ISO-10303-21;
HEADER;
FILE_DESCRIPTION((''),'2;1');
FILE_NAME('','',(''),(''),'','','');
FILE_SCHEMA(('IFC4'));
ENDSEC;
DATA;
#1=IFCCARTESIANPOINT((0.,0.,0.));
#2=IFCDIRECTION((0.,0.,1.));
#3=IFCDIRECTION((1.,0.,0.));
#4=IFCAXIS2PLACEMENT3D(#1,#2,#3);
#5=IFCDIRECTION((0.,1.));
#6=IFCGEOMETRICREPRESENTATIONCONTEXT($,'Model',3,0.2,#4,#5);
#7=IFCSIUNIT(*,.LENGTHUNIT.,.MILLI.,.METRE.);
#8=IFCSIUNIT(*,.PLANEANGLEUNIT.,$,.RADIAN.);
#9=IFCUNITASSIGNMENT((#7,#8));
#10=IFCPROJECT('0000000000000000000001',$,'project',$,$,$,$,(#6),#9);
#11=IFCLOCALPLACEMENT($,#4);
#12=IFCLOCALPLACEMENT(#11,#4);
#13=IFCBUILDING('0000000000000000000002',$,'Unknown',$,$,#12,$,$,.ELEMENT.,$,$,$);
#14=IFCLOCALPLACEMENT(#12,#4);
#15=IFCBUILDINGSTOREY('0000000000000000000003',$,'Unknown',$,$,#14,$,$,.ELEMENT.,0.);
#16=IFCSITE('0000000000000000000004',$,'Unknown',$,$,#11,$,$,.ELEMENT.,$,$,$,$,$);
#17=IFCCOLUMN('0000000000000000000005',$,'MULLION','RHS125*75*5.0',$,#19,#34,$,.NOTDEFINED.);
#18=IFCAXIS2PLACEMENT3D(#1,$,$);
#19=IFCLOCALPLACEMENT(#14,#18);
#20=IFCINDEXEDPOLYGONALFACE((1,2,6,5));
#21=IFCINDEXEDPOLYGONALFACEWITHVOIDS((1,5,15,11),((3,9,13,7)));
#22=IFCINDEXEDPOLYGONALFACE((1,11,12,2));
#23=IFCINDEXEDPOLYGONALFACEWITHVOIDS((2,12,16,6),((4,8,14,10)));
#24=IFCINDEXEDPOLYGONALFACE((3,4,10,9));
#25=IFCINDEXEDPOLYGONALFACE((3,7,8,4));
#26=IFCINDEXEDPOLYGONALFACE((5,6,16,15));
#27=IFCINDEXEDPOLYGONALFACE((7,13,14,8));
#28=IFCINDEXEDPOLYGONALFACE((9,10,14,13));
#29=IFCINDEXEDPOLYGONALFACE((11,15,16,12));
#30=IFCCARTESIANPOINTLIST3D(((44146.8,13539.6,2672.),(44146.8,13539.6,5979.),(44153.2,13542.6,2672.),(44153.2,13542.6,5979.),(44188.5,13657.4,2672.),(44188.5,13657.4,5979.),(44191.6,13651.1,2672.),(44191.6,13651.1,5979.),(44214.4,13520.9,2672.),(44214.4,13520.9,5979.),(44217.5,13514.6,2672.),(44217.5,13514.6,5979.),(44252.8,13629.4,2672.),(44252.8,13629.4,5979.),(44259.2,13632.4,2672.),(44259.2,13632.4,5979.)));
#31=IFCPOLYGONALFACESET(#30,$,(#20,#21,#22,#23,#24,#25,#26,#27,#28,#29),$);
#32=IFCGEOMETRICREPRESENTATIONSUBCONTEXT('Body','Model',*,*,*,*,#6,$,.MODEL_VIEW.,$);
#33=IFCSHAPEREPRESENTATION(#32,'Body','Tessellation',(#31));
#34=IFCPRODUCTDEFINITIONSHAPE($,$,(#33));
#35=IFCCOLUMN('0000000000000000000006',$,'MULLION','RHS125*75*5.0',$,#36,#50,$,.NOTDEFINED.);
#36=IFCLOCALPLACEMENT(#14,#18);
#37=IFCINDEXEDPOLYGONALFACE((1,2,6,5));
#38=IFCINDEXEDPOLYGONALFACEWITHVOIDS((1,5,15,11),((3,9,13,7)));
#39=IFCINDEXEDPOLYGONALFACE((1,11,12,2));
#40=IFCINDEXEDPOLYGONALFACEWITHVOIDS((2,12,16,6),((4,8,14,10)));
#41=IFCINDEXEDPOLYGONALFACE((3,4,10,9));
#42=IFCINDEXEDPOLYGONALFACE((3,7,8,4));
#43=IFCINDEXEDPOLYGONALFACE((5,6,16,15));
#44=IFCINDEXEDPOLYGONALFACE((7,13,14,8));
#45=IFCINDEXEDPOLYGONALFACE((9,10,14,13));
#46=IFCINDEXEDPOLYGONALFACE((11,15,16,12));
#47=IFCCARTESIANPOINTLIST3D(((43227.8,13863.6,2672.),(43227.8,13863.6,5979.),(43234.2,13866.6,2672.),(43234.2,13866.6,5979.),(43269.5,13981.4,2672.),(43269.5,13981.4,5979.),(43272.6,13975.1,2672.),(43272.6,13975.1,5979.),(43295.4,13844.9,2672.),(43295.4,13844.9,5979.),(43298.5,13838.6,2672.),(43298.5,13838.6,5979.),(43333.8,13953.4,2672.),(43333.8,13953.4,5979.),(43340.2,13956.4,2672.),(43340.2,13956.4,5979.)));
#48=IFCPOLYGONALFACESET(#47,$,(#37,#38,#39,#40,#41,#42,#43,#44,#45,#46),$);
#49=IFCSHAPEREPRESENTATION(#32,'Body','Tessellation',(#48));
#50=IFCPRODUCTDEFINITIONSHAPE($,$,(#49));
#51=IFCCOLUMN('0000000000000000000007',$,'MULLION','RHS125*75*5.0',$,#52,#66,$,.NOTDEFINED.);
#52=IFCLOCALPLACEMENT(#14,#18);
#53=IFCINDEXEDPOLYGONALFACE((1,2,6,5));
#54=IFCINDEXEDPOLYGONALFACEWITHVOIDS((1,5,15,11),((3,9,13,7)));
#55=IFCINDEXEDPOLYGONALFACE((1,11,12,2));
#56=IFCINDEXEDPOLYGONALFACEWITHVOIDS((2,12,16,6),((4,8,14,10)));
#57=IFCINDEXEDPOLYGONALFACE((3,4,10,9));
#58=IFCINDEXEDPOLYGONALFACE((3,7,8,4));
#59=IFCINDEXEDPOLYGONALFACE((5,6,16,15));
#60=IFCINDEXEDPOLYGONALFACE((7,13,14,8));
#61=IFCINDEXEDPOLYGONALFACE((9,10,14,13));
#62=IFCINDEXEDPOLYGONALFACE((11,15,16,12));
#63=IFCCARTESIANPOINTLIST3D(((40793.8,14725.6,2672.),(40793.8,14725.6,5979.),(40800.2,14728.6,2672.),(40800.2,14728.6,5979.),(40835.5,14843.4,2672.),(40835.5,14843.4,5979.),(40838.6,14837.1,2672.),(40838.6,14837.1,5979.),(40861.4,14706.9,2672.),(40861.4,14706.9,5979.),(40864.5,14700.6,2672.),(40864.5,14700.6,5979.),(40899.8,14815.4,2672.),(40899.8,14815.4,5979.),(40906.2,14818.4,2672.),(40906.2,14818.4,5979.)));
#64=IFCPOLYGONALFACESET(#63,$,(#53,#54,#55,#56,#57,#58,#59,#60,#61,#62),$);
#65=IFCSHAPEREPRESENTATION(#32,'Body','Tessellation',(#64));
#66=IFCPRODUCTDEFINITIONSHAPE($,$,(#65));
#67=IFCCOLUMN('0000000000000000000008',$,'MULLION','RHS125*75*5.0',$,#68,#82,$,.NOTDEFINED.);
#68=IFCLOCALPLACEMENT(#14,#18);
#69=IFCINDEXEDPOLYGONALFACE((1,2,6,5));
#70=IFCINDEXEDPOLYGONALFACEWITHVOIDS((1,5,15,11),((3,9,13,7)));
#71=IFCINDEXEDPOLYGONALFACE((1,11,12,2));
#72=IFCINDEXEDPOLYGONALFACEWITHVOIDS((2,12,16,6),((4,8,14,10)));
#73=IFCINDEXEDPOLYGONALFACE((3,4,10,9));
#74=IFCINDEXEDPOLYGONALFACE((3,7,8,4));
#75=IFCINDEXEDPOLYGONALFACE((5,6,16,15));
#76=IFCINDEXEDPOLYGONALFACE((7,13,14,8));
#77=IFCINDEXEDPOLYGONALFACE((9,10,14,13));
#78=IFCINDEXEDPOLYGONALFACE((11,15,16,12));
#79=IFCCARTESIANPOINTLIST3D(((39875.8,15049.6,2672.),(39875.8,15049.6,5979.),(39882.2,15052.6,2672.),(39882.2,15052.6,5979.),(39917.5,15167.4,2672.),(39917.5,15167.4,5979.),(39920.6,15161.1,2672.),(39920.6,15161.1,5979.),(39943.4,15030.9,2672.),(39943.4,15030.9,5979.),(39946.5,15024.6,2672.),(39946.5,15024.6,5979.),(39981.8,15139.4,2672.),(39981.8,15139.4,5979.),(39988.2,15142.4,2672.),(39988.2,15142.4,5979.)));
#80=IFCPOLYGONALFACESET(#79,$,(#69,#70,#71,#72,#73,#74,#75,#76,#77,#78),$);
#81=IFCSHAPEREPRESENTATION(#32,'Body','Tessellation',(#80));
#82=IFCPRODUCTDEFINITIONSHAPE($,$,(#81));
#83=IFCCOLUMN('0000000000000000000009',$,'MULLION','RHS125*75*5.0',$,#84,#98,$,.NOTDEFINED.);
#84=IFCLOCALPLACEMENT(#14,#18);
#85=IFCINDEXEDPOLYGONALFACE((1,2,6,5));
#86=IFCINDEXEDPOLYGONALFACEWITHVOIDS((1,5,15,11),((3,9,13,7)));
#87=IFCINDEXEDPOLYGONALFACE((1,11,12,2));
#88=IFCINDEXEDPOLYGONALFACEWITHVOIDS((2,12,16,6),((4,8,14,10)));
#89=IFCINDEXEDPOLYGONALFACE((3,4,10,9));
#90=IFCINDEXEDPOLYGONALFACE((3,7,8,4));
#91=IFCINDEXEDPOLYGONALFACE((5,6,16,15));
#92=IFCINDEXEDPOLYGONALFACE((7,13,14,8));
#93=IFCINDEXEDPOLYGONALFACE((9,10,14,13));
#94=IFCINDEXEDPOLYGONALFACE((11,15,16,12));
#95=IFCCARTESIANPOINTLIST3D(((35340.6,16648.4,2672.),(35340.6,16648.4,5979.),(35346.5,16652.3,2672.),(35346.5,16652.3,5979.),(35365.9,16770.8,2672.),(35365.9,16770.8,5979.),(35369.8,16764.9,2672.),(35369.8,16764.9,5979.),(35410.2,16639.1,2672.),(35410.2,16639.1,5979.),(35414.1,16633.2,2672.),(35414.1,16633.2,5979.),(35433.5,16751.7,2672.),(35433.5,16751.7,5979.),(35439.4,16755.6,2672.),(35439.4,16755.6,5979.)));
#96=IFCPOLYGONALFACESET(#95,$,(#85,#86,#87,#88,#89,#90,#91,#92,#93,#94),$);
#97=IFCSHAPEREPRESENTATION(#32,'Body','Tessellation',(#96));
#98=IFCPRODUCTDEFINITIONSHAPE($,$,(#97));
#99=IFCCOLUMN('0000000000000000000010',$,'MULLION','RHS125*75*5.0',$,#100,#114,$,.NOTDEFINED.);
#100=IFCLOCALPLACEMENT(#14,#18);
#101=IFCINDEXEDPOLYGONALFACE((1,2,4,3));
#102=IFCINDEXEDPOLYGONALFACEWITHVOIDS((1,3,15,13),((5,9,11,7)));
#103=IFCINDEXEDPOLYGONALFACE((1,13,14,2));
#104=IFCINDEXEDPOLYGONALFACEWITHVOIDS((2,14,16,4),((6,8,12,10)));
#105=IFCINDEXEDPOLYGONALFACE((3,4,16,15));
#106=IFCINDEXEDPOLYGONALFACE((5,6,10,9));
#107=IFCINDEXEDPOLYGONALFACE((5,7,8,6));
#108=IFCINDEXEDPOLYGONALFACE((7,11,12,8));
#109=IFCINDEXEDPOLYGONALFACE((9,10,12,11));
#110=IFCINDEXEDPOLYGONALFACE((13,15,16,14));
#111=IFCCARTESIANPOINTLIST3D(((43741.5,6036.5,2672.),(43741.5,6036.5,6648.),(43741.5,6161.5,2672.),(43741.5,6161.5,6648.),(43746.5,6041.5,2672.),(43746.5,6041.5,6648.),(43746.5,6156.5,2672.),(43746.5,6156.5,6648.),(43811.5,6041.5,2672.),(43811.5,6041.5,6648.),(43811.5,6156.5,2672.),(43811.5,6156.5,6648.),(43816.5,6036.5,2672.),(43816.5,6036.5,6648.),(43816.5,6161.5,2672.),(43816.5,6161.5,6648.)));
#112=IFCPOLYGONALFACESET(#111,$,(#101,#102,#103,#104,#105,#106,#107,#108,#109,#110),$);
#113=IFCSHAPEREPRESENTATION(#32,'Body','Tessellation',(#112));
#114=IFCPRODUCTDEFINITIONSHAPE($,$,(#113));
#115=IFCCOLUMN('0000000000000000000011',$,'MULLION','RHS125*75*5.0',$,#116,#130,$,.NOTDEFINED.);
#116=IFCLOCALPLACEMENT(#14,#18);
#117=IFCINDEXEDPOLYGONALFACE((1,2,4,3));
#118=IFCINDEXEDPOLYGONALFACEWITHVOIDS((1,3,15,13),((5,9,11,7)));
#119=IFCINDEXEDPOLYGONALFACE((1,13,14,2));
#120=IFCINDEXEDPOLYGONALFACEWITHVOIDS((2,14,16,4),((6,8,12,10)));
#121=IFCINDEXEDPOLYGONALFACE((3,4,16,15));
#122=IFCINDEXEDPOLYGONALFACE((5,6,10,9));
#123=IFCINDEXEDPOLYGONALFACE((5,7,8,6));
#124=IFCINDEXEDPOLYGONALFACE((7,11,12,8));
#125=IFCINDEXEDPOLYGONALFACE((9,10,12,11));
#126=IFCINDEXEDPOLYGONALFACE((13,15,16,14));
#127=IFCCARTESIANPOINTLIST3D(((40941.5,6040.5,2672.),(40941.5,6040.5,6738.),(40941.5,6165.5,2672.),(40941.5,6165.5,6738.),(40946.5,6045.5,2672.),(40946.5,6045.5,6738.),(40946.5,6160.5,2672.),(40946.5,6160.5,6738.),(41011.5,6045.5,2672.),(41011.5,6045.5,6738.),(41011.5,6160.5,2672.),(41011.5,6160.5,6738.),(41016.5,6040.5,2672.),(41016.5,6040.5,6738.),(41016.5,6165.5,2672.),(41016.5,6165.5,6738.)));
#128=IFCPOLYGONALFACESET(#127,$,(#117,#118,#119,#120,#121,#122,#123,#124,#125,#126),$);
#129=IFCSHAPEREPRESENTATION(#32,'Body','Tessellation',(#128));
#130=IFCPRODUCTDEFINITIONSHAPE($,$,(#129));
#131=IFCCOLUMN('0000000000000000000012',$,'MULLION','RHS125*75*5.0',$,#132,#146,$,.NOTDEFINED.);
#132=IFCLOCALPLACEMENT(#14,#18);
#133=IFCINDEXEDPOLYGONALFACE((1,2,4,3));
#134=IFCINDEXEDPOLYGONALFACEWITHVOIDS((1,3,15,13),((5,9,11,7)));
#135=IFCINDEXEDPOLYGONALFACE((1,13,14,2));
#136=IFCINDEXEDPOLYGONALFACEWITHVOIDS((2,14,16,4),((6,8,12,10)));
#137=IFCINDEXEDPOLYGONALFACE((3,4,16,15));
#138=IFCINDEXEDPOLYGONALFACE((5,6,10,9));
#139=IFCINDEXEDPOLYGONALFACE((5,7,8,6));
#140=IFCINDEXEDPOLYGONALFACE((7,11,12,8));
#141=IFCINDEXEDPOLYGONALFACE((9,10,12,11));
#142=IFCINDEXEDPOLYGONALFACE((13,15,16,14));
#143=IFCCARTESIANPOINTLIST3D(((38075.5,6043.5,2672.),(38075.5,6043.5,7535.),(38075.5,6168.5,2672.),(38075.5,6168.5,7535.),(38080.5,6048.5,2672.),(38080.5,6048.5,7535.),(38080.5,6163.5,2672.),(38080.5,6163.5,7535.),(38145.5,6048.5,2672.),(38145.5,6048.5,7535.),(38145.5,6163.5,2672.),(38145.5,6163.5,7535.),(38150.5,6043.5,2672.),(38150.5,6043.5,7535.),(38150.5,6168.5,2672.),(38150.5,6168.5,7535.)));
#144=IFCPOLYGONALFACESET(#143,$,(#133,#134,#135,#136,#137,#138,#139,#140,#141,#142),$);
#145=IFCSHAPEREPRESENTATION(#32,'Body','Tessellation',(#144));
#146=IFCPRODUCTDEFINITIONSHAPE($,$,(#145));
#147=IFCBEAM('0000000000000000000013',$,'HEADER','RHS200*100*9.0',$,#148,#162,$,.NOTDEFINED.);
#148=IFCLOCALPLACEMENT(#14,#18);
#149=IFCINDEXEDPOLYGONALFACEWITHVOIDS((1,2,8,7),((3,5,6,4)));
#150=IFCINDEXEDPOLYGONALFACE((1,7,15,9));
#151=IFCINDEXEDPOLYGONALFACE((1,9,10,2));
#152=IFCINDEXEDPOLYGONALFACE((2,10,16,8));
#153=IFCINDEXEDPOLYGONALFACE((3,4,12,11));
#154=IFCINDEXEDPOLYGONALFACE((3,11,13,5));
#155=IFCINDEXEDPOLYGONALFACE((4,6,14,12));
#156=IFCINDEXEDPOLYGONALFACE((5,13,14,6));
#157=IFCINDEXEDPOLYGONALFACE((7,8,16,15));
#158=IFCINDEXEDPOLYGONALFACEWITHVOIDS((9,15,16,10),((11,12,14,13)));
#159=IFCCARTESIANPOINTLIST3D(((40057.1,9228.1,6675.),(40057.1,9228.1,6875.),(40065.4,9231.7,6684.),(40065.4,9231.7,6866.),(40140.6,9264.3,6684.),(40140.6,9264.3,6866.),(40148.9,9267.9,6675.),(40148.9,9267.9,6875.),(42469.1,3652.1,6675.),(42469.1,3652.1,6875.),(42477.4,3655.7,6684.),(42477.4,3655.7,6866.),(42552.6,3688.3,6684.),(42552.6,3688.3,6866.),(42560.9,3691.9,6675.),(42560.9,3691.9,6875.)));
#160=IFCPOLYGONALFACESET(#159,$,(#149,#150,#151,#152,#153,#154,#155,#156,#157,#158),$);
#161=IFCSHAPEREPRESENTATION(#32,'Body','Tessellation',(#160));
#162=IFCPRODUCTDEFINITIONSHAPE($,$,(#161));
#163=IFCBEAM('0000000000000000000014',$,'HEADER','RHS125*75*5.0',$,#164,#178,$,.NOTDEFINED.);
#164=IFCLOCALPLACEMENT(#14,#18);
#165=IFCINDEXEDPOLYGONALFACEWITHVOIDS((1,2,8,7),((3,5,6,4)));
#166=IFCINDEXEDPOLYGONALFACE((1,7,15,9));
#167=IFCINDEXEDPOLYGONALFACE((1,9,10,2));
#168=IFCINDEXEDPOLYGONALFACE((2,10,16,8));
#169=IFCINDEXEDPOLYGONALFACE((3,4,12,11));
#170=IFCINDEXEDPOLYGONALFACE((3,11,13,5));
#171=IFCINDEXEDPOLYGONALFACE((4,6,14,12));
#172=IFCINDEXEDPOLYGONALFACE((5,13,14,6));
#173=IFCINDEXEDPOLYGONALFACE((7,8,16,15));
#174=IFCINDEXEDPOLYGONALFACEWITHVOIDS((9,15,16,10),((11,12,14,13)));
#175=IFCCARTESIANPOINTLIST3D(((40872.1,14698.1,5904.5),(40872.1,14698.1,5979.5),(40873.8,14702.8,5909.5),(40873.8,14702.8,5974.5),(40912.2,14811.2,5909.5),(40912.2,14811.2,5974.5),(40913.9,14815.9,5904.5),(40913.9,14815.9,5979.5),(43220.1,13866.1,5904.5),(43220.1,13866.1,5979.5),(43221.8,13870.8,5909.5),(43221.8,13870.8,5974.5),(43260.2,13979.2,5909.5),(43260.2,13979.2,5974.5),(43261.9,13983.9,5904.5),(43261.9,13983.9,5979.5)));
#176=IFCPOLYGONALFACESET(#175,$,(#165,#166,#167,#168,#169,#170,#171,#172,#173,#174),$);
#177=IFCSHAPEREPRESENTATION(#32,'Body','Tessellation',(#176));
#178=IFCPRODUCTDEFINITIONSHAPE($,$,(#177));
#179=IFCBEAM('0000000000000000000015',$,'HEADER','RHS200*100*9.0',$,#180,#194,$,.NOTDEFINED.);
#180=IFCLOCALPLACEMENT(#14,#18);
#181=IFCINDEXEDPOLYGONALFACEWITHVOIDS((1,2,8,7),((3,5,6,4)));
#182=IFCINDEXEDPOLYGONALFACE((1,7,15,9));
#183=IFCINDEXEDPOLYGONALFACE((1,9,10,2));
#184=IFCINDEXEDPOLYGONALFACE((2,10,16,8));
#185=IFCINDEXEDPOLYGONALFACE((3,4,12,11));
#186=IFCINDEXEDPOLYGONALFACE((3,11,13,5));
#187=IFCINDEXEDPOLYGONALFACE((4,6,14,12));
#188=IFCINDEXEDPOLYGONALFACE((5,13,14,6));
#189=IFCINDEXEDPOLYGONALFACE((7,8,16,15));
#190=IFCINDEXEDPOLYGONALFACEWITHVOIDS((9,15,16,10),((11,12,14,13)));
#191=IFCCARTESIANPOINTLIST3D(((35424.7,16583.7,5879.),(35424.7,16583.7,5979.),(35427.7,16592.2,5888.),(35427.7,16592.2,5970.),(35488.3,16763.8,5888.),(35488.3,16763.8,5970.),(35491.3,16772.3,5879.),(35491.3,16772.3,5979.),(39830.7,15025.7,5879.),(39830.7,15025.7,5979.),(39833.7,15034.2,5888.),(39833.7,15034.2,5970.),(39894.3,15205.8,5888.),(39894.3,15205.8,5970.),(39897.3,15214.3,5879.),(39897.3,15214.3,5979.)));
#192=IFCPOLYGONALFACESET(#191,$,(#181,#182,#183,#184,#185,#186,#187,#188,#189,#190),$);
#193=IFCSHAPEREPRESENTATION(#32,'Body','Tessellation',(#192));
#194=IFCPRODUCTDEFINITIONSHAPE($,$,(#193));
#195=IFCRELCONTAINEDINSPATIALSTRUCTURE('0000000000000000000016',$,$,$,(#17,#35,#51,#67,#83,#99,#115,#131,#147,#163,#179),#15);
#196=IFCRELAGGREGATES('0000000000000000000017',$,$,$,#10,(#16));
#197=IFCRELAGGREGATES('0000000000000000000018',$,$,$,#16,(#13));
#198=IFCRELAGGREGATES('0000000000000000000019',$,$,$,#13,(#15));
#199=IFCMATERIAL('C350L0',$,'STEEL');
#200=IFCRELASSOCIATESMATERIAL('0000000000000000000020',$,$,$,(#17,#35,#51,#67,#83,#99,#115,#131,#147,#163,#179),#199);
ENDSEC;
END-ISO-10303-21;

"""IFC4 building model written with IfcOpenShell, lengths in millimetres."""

from ifc_helpers import new_model, si_unit, direction, frame, origin_with_axes, place, context, subcontext, project, spatial, line, indexed_curve, outline, extrude, material, element, save


model = new_model("IFC4")

# Units and contexts
model_context = context("Model", 3, precision=0.2, world=origin_with_axes(), true_north=direction((0.0, 1.0)))
body_context = subcontext(model_context, "Body", "Model", "MODEL_VIEW")
ifc_project = project(units=[si_unit("LENGTHUNIT", "METRE", prefix="MILLI"), si_unit("PLANEANGLEUNIT", "RADIAN")], contexts=[model_context])

# Site, building, storey
site_placement = place(None, origin_with_axes())
site = spatial("IfcSite", under=ifc_project, at=site_placement, Name="Unknown", CompositionType="ELEMENT")
building_placement = place(site_placement, origin_with_axes())
building = spatial("IfcBuilding", under=site, at=building_placement, Name="Unknown", CompositionType="ELEMENT")
storey_placement = place(building_placement, origin_with_axes())
storey = spatial("IfcBuildingStorey", under=building, at=storey_placement, Name="Unknown", CompositionType="ELEMENT", Elevation=0.0)

# Columns
ifc_material_1 = material(Name="C350L0", Category="STEEL")
for number, where, z_axis, x_axis, name in (
    (1, (44203.0, 13586.0, 2672.0), (0.942641, -0.333807, 0.0), (0.0, 0.0, 1.0), "MULLION"),
    (2, (43284.0, 13910.0, 2672.0), (0.942641, -0.333807, 0.0), (0.0, 0.0, 1.0), "MULLION"),
    (3, (40850.0, 14772.0, 2672.0), (0.942641, -0.333807, 0.0), (0.0, 0.0, 1.0), "MULLION"),
    (4, (39932.0, 15096.0, 2672.0), (0.942641, -0.333807, 0.0), (0.0, 0.0, 1.0), "MULLION"),
    (5, (35390.0, 16702.0, 2672.0), (0.979364, -0.202104, 0.0), (0.0, 0.0, 1.0), "MULLION"),
):
    element("IfcColumn", number, at=place(storey_placement, frame(where, z_axis=z_axis, x_axis=x_axis)), inside=storey, material=ifc_material_1, Name=name, Description="RHS125*75*5.0", PredefinedType="NOTDEFINED", context=body_context, shape_type="SolidModel", body=[
        extrude(outline(indexed_curve([(-37.5, -62.5), (37.5, -62.5), (37.5, 62.5), (-37.5, 62.5)], segments=[line(1, 2, 3, 4, 1)]), holes=[indexed_curve([(-32.5, -57.5), (-32.5, 57.5), (32.5, 57.5), (32.5, -57.5)], segments=[line(1, 2, 3, 4, 1)])]), frame((0.0, 0.0, 0.0), z_axis=(-1.0, 0.0, 0.0), x_axis=(0.0, 0.0, 1.0)), (0.0, 0.0, -1.0), 3307.0),
    ])
column_1_placement = place(storey_placement, frame((43779.0, 6099.0, 2672.0), z_axis=(1.0, 0.0, 0.0), x_axis=(0.0, 0.0, 1.0)))
element("IfcColumn", 6, at=column_1_placement, inside=storey, material=ifc_material_1, Name="MULLION", Description="RHS125*75*5.0", PredefinedType="NOTDEFINED", context=body_context, shape_type="SolidModel", body=[
    extrude(outline(indexed_curve([(-37.5, -62.5), (37.5, -62.5), (37.5, 62.5), (-37.5, 62.5)], segments=[line(1, 2, 3, 4, 1)]), holes=[indexed_curve([(-32.5, -57.5), (-32.5, 57.5), (32.5, 57.5), (32.5, -57.5)], segments=[line(1, 2, 3, 4, 1)])]), frame((0.0, 0.0, 0.0), z_axis=(-1.0, 0.0, 0.0), x_axis=(0.0, 0.0, 1.0)), (0.0, 0.0, -1.0), 3976.0),
])
column_2_placement = place(storey_placement, frame((40979.0, 6103.0, 2672.0), z_axis=(1.0, 0.0, 0.0), x_axis=(0.0, 0.0, 1.0)))
element("IfcColumn", 7, at=column_2_placement, inside=storey, material=ifc_material_1, Name="MULLION", Description="RHS125*75*5.0", PredefinedType="NOTDEFINED", context=body_context, shape_type="SolidModel", body=[
    extrude(outline(indexed_curve([(-37.5, -62.5), (37.5, -62.5), (37.5, 62.5), (-37.5, 62.5)], segments=[line(1, 2, 3, 4, 1)]), holes=[indexed_curve([(-32.5, -57.5), (-32.5, 57.5), (32.5, 57.5), (32.5, -57.5)], segments=[line(1, 2, 3, 4, 1)])]), frame((0.0, 0.0, 0.0), z_axis=(-1.0, 0.0, 0.0), x_axis=(0.0, 0.0, 1.0)), (0.0, 0.0, -1.0), 4066.0),
])
column_3_placement = place(storey_placement, frame((38113.0, 6106.0, 2672.0), z_axis=(1.0, 0.0, 0.0), x_axis=(0.0, 0.0, 1.0)))
element("IfcColumn", 8, at=column_3_placement, inside=storey, material=ifc_material_1, Name="MULLION", Description="RHS125*75*5.0", PredefinedType="NOTDEFINED", context=body_context, shape_type="SolidModel", body=[
    extrude(outline(indexed_curve([(-37.5, -62.5), (37.5, -62.5), (37.5, 62.5), (-37.5, 62.5)], segments=[line(1, 2, 3, 4, 1)]), holes=[indexed_curve([(-32.5, -57.5), (-32.5, 57.5), (32.5, 57.5), (32.5, -57.5)], segments=[line(1, 2, 3, 4, 1)])]), frame((0.0, 0.0, 0.0), z_axis=(-1.0, 0.0, 0.0), x_axis=(0.0, 0.0, 1.0)), (0.0, 0.0, -1.0), 4863.0),
])

# Beams
beam_1_placement = place(storey_placement, frame((40103.0, 9248.0, 6775.0), z_axis=(-0.917812, -0.397016, 0.0), x_axis=(0.397016, -0.917812, 0.0)))
element("IfcBeam", 9, at=beam_1_placement, inside=storey, material=ifc_material_1, Name="HEADER", Description="RHS200*100*9.0", PredefinedType="NOTDEFINED", context=body_context, shape_type="SolidModel", body=[
    extrude(outline(indexed_curve([(-50.0, -100.0), (50.0, -100.0), (50.0, 100.0), (-50.0, 100.0)], segments=[line(1, 2, 3, 4, 1)]), holes=[indexed_curve([(-41.0, -91.0), (-41.0, 91.0), (41.0, 91.0), (41.0, -91.0)], segments=[line(1, 2, 3, 4, 1)])]), frame((0.0, 0.0, 0.0), z_axis=(-1.0, 0.0, 0.0), x_axis=(0.0, 0.0, 1.0)), (0.0, 0.0, -1.0), 6075.3),
])
beam_2_placement = place(storey_placement, frame((40893.0, 14757.0, 5942.0), z_axis=(0.0, 0.0, 1.0), x_axis=(0.942575, -0.333996, 0.0)))
element("IfcBeam", 10, at=beam_2_placement, inside=storey, material=ifc_material_1, Name="HEADER", Description="RHS125*75*5.0", PredefinedType="NOTDEFINED", context=body_context, shape_type="SolidModel", body=[
    extrude(outline(indexed_curve([(-37.5, -62.5), (37.5, -62.5), (37.5, 62.5), (-37.5, 62.5)], segments=[line(1, 2, 3, 4, 1)]), holes=[indexed_curve([(-32.5, -57.5), (-32.5, 57.5), (32.5, 57.5), (32.5, -57.5)], segments=[line(1, 2, 3, 4, 1)])]), frame((0.0, 0.0, 0.0), z_axis=(-1.0, 0.0, 0.0), x_axis=(0.0, 0.0, 1.0)), (0.0, 0.0, -1.0), 2491.0),
])
beam_3_placement = place(storey_placement, frame((35458.0, 16678.0, 5929.0), z_axis=(0.0, 0.0, 1.0), x_axis=(0.942793, -0.33338, 0.0)))
element("IfcBeam", 11, at=beam_3_placement, inside=storey, material=ifc_material_1, Name="HEADER", Description="RHS200*100*9.0", PredefinedType="NOTDEFINED", context=body_context, shape_type="SolidModel", body=[
    extrude(outline(indexed_curve([(-50.0, -100.0), (50.0, -100.0), (50.0, 100.0), (-50.0, 100.0)], segments=[line(1, 2, 3, 4, 1)]), holes=[indexed_curve([(-41.0, -91.0), (-41.0, 91.0), (41.0, 91.0), (41.0, -91.0)], segments=[line(1, 2, 3, 4, 1)])]), frame((0.0, 0.0, 0.0), z_axis=(-1.0, 0.0, 0.0), x_axis=(0.0, 0.0, 1.0)), (0.0, 0.0, -1.0), 4673.3),
])

save(model, "model.ifc")
